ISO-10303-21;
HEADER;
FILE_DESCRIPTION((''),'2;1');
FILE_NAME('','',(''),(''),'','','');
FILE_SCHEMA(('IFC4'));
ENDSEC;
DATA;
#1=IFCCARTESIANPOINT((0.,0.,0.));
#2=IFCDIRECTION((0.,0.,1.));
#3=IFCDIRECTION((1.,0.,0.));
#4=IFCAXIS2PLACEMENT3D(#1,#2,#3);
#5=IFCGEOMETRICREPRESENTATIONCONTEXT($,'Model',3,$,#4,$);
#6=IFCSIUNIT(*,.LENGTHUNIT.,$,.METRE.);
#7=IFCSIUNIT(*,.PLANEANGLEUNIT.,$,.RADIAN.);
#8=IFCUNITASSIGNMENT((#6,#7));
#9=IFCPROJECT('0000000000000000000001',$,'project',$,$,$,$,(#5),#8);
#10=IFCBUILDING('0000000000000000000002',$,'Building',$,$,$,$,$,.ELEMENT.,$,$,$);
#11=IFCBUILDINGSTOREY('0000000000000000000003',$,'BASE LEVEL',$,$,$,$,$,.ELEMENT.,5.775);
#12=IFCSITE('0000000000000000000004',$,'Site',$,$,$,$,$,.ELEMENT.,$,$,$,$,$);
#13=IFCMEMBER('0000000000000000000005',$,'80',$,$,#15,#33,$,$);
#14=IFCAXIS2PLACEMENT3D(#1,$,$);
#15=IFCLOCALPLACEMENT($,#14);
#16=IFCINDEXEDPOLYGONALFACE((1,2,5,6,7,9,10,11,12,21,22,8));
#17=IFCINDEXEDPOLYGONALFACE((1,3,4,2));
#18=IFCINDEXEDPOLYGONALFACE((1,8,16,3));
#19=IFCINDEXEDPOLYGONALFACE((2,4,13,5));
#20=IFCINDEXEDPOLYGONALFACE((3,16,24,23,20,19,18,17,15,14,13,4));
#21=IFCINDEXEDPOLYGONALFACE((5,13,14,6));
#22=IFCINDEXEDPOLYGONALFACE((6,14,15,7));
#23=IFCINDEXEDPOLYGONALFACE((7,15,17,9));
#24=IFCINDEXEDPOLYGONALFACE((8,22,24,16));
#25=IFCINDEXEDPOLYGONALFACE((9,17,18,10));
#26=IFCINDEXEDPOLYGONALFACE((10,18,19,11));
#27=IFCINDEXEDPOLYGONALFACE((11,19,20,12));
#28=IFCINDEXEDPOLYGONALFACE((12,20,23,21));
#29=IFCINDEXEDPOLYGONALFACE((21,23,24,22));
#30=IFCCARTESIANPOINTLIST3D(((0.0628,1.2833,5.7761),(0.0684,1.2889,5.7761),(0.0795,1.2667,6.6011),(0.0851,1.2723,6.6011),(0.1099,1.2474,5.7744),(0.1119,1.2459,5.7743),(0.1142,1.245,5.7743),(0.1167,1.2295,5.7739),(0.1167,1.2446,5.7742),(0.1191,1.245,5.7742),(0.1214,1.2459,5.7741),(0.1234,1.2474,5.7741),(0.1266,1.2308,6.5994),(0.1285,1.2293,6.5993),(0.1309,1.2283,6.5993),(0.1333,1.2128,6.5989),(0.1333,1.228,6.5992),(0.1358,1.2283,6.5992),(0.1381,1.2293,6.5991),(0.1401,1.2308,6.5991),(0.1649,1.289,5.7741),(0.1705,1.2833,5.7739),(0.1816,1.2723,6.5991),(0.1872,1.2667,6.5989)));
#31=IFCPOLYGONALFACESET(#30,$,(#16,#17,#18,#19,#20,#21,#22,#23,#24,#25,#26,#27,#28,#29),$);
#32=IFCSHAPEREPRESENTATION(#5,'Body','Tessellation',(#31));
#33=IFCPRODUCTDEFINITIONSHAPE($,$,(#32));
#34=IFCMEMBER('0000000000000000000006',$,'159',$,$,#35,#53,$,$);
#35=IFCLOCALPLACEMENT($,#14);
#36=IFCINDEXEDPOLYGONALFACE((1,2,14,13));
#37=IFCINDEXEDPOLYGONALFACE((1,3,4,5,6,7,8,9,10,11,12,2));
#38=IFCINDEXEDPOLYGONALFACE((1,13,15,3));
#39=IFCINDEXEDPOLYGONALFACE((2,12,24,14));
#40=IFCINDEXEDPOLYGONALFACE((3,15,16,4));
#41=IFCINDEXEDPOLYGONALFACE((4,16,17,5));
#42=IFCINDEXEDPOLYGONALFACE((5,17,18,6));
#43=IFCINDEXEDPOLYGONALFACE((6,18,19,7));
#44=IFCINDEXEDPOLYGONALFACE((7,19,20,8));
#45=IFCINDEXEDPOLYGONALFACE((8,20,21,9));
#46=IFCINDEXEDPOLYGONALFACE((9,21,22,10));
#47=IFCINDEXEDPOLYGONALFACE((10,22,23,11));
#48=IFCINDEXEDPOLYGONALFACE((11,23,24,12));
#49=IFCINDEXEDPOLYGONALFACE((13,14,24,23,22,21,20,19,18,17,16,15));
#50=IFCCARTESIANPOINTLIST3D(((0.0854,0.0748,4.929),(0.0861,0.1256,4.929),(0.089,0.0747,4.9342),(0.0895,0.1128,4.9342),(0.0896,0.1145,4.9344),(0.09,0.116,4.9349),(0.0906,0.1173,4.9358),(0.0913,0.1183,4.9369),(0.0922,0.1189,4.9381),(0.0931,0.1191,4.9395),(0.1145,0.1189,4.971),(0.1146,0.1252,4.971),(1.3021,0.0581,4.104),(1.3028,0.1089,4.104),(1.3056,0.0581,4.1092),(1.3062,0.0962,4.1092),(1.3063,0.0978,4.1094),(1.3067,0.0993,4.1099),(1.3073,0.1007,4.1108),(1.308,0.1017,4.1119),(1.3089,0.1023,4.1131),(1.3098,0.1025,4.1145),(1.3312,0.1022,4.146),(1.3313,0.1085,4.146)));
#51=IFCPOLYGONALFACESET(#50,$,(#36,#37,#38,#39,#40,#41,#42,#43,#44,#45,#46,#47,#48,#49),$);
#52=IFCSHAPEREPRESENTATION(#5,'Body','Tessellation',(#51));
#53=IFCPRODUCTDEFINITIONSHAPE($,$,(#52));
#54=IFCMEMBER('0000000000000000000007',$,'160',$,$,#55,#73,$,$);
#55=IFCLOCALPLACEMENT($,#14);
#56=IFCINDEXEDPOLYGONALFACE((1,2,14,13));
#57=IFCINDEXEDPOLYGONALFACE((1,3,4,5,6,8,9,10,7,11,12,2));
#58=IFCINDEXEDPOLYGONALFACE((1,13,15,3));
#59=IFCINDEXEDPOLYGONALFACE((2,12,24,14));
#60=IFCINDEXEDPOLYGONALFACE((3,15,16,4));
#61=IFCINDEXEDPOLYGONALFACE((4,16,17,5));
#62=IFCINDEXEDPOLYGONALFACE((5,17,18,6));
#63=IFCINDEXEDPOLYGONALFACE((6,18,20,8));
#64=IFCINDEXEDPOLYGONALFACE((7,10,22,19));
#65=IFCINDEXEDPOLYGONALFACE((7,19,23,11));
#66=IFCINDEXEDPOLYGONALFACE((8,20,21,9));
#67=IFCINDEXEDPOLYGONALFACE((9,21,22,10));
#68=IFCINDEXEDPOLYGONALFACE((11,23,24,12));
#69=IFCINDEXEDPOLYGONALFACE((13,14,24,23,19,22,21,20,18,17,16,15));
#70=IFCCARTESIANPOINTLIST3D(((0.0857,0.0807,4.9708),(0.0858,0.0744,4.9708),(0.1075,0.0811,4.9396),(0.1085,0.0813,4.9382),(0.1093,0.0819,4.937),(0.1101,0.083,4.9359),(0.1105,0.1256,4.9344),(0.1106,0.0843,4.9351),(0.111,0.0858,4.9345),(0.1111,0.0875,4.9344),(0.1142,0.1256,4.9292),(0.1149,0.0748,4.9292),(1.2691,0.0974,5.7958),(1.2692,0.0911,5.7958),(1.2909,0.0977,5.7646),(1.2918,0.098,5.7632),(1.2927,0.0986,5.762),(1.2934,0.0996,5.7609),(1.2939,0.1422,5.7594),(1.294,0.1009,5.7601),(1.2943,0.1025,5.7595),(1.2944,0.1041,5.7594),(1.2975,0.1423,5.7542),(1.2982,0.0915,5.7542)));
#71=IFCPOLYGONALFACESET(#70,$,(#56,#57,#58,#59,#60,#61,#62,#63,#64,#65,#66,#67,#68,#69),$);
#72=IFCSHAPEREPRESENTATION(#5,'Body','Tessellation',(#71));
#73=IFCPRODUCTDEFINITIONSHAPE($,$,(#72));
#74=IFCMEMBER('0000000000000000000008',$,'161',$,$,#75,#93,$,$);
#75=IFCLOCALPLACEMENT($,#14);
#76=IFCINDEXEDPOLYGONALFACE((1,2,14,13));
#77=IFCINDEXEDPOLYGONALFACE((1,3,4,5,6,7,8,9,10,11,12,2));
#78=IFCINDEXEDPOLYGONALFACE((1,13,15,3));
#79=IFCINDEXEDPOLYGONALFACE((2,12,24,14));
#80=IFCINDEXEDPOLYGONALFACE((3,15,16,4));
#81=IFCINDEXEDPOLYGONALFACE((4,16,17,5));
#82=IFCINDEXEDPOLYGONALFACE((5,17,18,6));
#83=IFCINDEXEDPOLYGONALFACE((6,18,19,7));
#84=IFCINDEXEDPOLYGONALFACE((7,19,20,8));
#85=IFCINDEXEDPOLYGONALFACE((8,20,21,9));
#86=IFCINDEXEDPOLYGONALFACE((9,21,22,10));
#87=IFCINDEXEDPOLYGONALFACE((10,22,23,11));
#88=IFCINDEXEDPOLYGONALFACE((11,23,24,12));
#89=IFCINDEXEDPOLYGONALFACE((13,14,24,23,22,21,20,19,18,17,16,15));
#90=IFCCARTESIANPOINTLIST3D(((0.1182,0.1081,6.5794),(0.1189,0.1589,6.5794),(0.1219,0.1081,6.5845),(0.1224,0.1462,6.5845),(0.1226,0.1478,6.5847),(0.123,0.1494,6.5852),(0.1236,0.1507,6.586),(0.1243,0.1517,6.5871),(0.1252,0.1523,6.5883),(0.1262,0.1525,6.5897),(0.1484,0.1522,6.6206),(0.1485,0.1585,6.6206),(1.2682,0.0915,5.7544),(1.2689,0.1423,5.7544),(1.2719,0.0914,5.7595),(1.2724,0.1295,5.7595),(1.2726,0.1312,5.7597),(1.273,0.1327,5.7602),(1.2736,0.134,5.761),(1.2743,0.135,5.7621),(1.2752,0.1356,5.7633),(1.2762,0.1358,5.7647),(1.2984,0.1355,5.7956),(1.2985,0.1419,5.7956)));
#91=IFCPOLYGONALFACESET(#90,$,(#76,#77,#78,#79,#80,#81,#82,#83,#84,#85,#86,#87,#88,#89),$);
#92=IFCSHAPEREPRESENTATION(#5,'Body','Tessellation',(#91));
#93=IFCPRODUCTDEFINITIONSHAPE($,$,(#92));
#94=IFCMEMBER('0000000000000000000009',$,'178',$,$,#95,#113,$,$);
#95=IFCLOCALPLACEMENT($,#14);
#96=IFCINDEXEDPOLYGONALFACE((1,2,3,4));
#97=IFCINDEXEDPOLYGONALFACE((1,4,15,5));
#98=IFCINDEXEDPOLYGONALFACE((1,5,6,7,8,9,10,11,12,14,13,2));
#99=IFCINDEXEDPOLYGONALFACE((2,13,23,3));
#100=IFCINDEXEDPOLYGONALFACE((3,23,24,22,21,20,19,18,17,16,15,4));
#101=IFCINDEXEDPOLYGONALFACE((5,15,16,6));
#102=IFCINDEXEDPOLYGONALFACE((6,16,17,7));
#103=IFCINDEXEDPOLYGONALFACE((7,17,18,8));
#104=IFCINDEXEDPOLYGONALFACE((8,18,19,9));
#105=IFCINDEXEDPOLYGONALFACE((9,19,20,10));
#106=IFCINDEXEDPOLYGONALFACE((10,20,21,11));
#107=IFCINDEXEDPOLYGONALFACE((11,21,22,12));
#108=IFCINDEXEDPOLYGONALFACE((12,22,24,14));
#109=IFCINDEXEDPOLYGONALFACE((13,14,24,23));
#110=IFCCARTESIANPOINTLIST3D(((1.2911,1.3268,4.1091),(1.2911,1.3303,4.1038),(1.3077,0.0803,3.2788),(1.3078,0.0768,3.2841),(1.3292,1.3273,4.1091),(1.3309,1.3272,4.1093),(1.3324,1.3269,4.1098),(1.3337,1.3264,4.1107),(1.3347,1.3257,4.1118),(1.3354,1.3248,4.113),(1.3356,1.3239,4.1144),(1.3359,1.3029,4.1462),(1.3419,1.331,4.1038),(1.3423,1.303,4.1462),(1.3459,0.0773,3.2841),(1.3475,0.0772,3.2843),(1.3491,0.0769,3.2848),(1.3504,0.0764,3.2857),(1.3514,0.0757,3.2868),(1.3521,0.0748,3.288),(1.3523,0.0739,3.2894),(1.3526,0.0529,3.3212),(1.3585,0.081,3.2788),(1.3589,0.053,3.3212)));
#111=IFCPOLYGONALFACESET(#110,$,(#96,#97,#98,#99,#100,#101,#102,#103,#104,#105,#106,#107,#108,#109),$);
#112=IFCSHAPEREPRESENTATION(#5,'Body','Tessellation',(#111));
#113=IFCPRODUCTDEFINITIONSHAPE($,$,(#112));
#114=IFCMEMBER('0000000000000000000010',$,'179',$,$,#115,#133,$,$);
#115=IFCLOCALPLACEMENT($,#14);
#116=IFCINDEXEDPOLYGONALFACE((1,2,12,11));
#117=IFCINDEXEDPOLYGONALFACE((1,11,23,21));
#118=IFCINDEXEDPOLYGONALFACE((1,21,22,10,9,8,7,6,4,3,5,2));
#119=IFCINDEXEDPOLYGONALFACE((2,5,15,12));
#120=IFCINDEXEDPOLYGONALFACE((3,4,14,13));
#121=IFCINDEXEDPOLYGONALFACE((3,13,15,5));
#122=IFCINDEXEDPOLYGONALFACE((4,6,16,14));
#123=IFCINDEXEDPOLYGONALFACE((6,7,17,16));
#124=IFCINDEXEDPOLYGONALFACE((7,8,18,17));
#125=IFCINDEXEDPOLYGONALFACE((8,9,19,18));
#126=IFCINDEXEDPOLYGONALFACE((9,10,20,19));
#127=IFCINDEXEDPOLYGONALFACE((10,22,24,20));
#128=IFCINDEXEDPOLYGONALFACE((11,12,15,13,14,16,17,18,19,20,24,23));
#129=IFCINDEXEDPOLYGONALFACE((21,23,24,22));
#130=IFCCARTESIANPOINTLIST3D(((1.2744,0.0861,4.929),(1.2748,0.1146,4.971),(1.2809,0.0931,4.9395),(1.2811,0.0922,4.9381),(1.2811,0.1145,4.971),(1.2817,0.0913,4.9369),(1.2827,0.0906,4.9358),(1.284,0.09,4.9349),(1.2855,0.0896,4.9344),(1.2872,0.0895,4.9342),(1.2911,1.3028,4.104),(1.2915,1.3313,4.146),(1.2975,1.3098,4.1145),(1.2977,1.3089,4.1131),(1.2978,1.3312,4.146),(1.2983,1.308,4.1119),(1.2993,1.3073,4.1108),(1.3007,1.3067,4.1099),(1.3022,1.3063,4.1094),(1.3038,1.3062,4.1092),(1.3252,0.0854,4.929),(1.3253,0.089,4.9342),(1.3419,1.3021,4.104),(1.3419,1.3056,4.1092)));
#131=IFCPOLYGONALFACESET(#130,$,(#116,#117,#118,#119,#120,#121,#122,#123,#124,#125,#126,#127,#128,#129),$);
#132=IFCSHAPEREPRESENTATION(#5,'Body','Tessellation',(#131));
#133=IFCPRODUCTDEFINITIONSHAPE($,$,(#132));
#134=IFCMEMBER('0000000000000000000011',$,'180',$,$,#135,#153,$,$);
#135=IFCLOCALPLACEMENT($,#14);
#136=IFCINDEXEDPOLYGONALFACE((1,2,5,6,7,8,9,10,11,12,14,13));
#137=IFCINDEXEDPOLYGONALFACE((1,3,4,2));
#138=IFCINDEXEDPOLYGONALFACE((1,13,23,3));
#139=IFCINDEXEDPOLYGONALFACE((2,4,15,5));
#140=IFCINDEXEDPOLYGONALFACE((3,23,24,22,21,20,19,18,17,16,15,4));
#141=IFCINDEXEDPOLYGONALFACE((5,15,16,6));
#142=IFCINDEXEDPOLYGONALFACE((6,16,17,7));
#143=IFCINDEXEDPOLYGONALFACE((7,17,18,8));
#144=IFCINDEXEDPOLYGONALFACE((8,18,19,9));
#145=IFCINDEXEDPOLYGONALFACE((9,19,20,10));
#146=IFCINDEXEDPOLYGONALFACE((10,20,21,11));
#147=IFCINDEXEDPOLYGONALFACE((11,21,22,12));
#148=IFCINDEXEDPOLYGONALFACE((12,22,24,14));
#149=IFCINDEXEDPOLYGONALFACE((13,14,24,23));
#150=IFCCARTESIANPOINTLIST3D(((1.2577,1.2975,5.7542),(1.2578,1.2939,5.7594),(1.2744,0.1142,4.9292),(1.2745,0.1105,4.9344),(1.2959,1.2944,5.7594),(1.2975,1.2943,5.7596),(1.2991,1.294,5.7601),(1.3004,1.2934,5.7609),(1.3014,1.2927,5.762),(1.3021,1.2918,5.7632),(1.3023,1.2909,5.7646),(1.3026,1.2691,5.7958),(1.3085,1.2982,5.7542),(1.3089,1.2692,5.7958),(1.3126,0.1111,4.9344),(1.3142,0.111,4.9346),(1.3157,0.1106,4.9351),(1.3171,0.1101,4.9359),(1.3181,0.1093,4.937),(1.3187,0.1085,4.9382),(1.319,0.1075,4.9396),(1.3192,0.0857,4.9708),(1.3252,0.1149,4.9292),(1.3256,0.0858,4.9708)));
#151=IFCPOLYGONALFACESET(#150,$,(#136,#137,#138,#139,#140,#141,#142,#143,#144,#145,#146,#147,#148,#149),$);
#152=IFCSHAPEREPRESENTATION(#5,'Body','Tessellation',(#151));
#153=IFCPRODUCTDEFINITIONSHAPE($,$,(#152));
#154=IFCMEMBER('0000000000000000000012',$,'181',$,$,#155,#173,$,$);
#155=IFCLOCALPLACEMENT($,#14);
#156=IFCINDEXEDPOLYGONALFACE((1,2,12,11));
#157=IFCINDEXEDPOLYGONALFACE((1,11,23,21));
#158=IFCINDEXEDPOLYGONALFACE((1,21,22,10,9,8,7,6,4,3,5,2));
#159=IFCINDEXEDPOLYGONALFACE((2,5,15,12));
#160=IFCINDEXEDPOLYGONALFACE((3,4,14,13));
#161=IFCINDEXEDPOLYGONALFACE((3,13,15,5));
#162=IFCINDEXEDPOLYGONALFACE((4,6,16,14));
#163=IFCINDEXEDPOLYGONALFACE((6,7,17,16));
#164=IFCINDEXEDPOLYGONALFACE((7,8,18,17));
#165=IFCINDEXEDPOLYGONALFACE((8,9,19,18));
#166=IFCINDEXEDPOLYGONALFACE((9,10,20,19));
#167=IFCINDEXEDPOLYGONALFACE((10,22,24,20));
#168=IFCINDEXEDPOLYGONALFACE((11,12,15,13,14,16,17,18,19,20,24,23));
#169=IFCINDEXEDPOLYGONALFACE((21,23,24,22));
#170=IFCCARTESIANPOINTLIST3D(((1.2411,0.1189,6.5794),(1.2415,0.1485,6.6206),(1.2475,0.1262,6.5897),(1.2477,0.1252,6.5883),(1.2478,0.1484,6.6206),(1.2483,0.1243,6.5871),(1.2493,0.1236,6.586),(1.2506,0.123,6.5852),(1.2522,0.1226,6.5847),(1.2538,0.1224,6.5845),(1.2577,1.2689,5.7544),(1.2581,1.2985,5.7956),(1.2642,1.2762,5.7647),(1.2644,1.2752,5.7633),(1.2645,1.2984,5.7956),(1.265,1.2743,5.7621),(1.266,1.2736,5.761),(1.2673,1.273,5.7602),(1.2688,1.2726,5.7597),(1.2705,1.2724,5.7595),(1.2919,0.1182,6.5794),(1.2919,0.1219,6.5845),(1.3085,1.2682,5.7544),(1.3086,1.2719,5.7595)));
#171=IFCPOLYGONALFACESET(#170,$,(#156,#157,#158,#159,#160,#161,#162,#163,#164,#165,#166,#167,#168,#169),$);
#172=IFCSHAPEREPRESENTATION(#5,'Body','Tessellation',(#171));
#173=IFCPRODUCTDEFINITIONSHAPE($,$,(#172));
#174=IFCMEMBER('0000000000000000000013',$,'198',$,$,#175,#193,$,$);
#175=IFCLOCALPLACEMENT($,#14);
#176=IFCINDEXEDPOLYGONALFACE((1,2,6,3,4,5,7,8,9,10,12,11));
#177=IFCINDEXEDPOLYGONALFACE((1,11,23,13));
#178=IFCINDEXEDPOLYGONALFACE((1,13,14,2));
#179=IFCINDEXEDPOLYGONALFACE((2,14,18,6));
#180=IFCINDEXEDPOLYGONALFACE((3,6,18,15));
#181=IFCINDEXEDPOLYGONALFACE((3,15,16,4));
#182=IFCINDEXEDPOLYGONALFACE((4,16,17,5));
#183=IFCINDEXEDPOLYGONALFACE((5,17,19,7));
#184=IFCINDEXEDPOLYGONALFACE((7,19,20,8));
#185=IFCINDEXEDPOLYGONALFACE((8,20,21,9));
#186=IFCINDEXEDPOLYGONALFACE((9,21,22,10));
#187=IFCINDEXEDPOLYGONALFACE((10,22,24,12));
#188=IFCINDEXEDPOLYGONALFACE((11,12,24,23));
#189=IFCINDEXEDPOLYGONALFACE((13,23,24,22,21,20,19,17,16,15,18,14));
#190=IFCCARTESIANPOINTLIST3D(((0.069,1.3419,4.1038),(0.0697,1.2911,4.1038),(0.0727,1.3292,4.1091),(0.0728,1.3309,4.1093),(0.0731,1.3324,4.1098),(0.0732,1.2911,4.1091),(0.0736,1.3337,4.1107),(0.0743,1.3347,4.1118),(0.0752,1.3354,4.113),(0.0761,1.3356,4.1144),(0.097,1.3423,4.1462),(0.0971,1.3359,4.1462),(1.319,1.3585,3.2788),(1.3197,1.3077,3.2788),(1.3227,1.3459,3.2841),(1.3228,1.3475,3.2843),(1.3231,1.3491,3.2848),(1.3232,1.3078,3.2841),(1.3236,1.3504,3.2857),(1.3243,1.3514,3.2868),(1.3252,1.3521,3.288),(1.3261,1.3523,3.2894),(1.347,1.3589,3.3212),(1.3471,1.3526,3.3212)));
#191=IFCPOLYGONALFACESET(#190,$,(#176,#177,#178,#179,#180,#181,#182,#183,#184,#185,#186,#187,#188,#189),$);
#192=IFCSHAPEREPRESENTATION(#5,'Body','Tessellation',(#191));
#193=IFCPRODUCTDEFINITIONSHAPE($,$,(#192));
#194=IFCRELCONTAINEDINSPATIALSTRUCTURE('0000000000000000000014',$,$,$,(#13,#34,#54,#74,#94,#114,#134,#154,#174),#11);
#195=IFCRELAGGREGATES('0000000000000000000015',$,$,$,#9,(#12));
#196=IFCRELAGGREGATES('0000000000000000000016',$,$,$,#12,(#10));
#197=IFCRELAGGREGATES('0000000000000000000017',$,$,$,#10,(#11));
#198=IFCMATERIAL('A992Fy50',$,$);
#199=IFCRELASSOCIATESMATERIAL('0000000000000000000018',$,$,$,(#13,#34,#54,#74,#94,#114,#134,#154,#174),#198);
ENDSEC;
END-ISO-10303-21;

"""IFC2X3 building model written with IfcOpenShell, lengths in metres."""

from ifc_helpers import new_model, si_unit, frame, origin_with_axes, origin_2d_with_axis, place, context, project, spatial, l_section, extrude, material, element, save


model = new_model("IFC2X3")

# Units and contexts
model_context = context("Model", 3, world=origin_with_axes())
ifc_project = project(units=[si_unit("LENGTHUNIT", "METRE"), si_unit("PLANEANGLEUNIT", "RADIAN")], contexts=[model_context])

# Site, building, storey
site = spatial("IfcSite", under=ifc_project, Name="Site", CompositionType="ELEMENT")
building = spatial("IfcBuilding", under=site, Name="Building", CompositionType="ELEMENT")
storey = spatial("IfcBuildingStorey", under=building, Name="BASE LEVEL", CompositionType="ELEMENT", Elevation=5.775)

# Members
ifc_material = material(Name="A992Fy50")
for number, where, z_axis, x_axis, name in (
    (1, (0.1167, 1.2833, 5.775), (0.020194, -0.020194, 0.999592), (0.707107, 0.707107, 0.0), "80"),
):
    element("IfcMember", number, at=place(None, frame(where, z_axis=z_axis, x_axis=x_axis)), inside=storey, material=ifc_material, Name=name, context=model_context, shape_type="SweptSolid", body=[
        extrude(l_section(Depth=0.0762, Width=0.0762, Thickness=0.0079, FilletRadius=0.0096, at=origin_2d_with_axis()), origin_with_axes(), (0.0, 0.0, 1.0), 0.8253),
    ])
member_1_placement = place(None, frame((1.3167, 0.0833, 4.125), z_axis=(-0.827611, 0.011337, 0.561188), x_axis=(-0.013697, -0.999906, 0.0)))
element("IfcMember", 2, at=member_1_placement, inside=storey, material=ifc_material, Name="159", context=model_context, shape_type="SweptSolid", body=[
    extrude(l_section(Depth=0.0508, Width=0.0508, Thickness=0.0063, FilletRadius=0.0063, at=origin_2d_with_axis()), origin_with_axes(), (0.0, 0.0, 1.0), 1.4701),
])
member_2_placement = place(None, frame((0.1, 0.1, 4.95), z_axis=(0.820261, 0.011553, 0.571872), x_axis=(-0.014083, 0.999901, 0.0)))
element("IfcMember", 3, at=member_2_placement, inside=storey, material=ifc_material, Name="160", context=model_context, shape_type="SweptSolid", body=[
    extrude(l_section(Depth=0.0508, Width=0.0508, Thickness=0.0063, FilletRadius=0.0063, at=origin_2d_with_axis()), origin_with_axes(), (0.0, 0.0, 1.0), 1.4426),
])
member_3_placement = place(None, frame((1.2833, 0.1167, 5.775), z_axis=(-0.812482, 0.011775, 0.582867), x_axis=(-0.013697, -0.999906, 0.0)))
element("IfcMember", 4, at=member_3_placement, inside=storey, material=ifc_material, Name="161", context=model_context, shape_type="SweptSolid", body=[
    extrude(l_section(Depth=0.0508, Width=0.0508, Thickness=0.0063, FilletRadius=0.0063, at=origin_2d_with_axis()), origin_with_axes(), (0.0, 0.0, 1.0), 1.4154),
])
member_4_placement = place(None, frame((1.3333, 0.0667, 3.3), z_axis=(-0.011127, 0.834558, 0.550808), x_axis=(-0.999911, -0.013332, 0.0)))
element("IfcMember", 5, at=member_4_placement, inside=storey, material=ifc_material, Name="178", context=model_context, shape_type="SweptSolid", body=[
    extrude(l_section(Depth=0.0508, Width=0.0508, Thickness=0.0063, FilletRadius=0.0063, at=origin_2d_with_axis()), origin_with_axes(), (0.0, 0.0, 1.0), 1.4978),
])
member_5_placement = place(None, frame((1.3167, 1.3167, 4.125), z_axis=(-0.011337, -0.827611, 0.561188), x_axis=(0.999906, -0.013697, 0.0)))
element("IfcMember", 6, at=member_5_placement, inside=storey, material=ifc_material, Name="179", context=model_context, shape_type="SweptSolid", body=[
    extrude(l_section(Depth=0.0508, Width=0.0508, Thickness=0.0063, FilletRadius=0.0063, at=origin_2d_with_axis()), origin_with_axes(), (0.0, 0.0, 1.0), 1.4701),
])
member_6_placement = place(None, frame((1.3, 0.1, 4.95), z_axis=(-0.011553, 0.820261, 0.571872), x_axis=(-0.999911, -0.013332, 0.0)))
element("IfcMember", 7, at=member_6_placement, inside=storey, material=ifc_material, Name="180", context=model_context, shape_type="SweptSolid", body=[
    extrude(l_section(Depth=0.0508, Width=0.0508, Thickness=0.0063, FilletRadius=0.0063, at=origin_2d_with_axis()), origin_with_axes(), (0.0, 0.0, 1.0), 1.4426),
])
member_7_placement = place(None, frame((1.2833, 1.2833, 5.775), z_axis=(-0.011775, -0.812482, 0.582867), x_axis=(0.999906, -0.013697, 0.0)))
element("IfcMember", 8, at=member_7_placement, inside=storey, material=ifc_material, Name="181", context=model_context, shape_type="SweptSolid", body=[
    extrude(l_section(Depth=0.0508, Width=0.0508, Thickness=0.0063, FilletRadius=0.0063, at=origin_2d_with_axis()), origin_with_axes(), (0.0, 0.0, 1.0), 1.4154),
])
member_8_placement = place(None, frame((1.3333, 1.3333, 3.3), z_axis=(-0.834558, -0.011127, 0.550808), x_axis=(0.013332, -0.999911, 0.0)))
element("IfcMember", 9, at=member_8_placement, inside=storey, material=ifc_material, Name="198", context=model_context, shape_type="SweptSolid", body=[
    extrude(l_section(Depth=0.0508, Width=0.0508, Thickness=0.0063, FilletRadius=0.0063, at=origin_2d_with_axis()), origin_with_axes(), (0.0, 0.0, 1.0), 1.4978),
])

save(model, "model.ifc")
